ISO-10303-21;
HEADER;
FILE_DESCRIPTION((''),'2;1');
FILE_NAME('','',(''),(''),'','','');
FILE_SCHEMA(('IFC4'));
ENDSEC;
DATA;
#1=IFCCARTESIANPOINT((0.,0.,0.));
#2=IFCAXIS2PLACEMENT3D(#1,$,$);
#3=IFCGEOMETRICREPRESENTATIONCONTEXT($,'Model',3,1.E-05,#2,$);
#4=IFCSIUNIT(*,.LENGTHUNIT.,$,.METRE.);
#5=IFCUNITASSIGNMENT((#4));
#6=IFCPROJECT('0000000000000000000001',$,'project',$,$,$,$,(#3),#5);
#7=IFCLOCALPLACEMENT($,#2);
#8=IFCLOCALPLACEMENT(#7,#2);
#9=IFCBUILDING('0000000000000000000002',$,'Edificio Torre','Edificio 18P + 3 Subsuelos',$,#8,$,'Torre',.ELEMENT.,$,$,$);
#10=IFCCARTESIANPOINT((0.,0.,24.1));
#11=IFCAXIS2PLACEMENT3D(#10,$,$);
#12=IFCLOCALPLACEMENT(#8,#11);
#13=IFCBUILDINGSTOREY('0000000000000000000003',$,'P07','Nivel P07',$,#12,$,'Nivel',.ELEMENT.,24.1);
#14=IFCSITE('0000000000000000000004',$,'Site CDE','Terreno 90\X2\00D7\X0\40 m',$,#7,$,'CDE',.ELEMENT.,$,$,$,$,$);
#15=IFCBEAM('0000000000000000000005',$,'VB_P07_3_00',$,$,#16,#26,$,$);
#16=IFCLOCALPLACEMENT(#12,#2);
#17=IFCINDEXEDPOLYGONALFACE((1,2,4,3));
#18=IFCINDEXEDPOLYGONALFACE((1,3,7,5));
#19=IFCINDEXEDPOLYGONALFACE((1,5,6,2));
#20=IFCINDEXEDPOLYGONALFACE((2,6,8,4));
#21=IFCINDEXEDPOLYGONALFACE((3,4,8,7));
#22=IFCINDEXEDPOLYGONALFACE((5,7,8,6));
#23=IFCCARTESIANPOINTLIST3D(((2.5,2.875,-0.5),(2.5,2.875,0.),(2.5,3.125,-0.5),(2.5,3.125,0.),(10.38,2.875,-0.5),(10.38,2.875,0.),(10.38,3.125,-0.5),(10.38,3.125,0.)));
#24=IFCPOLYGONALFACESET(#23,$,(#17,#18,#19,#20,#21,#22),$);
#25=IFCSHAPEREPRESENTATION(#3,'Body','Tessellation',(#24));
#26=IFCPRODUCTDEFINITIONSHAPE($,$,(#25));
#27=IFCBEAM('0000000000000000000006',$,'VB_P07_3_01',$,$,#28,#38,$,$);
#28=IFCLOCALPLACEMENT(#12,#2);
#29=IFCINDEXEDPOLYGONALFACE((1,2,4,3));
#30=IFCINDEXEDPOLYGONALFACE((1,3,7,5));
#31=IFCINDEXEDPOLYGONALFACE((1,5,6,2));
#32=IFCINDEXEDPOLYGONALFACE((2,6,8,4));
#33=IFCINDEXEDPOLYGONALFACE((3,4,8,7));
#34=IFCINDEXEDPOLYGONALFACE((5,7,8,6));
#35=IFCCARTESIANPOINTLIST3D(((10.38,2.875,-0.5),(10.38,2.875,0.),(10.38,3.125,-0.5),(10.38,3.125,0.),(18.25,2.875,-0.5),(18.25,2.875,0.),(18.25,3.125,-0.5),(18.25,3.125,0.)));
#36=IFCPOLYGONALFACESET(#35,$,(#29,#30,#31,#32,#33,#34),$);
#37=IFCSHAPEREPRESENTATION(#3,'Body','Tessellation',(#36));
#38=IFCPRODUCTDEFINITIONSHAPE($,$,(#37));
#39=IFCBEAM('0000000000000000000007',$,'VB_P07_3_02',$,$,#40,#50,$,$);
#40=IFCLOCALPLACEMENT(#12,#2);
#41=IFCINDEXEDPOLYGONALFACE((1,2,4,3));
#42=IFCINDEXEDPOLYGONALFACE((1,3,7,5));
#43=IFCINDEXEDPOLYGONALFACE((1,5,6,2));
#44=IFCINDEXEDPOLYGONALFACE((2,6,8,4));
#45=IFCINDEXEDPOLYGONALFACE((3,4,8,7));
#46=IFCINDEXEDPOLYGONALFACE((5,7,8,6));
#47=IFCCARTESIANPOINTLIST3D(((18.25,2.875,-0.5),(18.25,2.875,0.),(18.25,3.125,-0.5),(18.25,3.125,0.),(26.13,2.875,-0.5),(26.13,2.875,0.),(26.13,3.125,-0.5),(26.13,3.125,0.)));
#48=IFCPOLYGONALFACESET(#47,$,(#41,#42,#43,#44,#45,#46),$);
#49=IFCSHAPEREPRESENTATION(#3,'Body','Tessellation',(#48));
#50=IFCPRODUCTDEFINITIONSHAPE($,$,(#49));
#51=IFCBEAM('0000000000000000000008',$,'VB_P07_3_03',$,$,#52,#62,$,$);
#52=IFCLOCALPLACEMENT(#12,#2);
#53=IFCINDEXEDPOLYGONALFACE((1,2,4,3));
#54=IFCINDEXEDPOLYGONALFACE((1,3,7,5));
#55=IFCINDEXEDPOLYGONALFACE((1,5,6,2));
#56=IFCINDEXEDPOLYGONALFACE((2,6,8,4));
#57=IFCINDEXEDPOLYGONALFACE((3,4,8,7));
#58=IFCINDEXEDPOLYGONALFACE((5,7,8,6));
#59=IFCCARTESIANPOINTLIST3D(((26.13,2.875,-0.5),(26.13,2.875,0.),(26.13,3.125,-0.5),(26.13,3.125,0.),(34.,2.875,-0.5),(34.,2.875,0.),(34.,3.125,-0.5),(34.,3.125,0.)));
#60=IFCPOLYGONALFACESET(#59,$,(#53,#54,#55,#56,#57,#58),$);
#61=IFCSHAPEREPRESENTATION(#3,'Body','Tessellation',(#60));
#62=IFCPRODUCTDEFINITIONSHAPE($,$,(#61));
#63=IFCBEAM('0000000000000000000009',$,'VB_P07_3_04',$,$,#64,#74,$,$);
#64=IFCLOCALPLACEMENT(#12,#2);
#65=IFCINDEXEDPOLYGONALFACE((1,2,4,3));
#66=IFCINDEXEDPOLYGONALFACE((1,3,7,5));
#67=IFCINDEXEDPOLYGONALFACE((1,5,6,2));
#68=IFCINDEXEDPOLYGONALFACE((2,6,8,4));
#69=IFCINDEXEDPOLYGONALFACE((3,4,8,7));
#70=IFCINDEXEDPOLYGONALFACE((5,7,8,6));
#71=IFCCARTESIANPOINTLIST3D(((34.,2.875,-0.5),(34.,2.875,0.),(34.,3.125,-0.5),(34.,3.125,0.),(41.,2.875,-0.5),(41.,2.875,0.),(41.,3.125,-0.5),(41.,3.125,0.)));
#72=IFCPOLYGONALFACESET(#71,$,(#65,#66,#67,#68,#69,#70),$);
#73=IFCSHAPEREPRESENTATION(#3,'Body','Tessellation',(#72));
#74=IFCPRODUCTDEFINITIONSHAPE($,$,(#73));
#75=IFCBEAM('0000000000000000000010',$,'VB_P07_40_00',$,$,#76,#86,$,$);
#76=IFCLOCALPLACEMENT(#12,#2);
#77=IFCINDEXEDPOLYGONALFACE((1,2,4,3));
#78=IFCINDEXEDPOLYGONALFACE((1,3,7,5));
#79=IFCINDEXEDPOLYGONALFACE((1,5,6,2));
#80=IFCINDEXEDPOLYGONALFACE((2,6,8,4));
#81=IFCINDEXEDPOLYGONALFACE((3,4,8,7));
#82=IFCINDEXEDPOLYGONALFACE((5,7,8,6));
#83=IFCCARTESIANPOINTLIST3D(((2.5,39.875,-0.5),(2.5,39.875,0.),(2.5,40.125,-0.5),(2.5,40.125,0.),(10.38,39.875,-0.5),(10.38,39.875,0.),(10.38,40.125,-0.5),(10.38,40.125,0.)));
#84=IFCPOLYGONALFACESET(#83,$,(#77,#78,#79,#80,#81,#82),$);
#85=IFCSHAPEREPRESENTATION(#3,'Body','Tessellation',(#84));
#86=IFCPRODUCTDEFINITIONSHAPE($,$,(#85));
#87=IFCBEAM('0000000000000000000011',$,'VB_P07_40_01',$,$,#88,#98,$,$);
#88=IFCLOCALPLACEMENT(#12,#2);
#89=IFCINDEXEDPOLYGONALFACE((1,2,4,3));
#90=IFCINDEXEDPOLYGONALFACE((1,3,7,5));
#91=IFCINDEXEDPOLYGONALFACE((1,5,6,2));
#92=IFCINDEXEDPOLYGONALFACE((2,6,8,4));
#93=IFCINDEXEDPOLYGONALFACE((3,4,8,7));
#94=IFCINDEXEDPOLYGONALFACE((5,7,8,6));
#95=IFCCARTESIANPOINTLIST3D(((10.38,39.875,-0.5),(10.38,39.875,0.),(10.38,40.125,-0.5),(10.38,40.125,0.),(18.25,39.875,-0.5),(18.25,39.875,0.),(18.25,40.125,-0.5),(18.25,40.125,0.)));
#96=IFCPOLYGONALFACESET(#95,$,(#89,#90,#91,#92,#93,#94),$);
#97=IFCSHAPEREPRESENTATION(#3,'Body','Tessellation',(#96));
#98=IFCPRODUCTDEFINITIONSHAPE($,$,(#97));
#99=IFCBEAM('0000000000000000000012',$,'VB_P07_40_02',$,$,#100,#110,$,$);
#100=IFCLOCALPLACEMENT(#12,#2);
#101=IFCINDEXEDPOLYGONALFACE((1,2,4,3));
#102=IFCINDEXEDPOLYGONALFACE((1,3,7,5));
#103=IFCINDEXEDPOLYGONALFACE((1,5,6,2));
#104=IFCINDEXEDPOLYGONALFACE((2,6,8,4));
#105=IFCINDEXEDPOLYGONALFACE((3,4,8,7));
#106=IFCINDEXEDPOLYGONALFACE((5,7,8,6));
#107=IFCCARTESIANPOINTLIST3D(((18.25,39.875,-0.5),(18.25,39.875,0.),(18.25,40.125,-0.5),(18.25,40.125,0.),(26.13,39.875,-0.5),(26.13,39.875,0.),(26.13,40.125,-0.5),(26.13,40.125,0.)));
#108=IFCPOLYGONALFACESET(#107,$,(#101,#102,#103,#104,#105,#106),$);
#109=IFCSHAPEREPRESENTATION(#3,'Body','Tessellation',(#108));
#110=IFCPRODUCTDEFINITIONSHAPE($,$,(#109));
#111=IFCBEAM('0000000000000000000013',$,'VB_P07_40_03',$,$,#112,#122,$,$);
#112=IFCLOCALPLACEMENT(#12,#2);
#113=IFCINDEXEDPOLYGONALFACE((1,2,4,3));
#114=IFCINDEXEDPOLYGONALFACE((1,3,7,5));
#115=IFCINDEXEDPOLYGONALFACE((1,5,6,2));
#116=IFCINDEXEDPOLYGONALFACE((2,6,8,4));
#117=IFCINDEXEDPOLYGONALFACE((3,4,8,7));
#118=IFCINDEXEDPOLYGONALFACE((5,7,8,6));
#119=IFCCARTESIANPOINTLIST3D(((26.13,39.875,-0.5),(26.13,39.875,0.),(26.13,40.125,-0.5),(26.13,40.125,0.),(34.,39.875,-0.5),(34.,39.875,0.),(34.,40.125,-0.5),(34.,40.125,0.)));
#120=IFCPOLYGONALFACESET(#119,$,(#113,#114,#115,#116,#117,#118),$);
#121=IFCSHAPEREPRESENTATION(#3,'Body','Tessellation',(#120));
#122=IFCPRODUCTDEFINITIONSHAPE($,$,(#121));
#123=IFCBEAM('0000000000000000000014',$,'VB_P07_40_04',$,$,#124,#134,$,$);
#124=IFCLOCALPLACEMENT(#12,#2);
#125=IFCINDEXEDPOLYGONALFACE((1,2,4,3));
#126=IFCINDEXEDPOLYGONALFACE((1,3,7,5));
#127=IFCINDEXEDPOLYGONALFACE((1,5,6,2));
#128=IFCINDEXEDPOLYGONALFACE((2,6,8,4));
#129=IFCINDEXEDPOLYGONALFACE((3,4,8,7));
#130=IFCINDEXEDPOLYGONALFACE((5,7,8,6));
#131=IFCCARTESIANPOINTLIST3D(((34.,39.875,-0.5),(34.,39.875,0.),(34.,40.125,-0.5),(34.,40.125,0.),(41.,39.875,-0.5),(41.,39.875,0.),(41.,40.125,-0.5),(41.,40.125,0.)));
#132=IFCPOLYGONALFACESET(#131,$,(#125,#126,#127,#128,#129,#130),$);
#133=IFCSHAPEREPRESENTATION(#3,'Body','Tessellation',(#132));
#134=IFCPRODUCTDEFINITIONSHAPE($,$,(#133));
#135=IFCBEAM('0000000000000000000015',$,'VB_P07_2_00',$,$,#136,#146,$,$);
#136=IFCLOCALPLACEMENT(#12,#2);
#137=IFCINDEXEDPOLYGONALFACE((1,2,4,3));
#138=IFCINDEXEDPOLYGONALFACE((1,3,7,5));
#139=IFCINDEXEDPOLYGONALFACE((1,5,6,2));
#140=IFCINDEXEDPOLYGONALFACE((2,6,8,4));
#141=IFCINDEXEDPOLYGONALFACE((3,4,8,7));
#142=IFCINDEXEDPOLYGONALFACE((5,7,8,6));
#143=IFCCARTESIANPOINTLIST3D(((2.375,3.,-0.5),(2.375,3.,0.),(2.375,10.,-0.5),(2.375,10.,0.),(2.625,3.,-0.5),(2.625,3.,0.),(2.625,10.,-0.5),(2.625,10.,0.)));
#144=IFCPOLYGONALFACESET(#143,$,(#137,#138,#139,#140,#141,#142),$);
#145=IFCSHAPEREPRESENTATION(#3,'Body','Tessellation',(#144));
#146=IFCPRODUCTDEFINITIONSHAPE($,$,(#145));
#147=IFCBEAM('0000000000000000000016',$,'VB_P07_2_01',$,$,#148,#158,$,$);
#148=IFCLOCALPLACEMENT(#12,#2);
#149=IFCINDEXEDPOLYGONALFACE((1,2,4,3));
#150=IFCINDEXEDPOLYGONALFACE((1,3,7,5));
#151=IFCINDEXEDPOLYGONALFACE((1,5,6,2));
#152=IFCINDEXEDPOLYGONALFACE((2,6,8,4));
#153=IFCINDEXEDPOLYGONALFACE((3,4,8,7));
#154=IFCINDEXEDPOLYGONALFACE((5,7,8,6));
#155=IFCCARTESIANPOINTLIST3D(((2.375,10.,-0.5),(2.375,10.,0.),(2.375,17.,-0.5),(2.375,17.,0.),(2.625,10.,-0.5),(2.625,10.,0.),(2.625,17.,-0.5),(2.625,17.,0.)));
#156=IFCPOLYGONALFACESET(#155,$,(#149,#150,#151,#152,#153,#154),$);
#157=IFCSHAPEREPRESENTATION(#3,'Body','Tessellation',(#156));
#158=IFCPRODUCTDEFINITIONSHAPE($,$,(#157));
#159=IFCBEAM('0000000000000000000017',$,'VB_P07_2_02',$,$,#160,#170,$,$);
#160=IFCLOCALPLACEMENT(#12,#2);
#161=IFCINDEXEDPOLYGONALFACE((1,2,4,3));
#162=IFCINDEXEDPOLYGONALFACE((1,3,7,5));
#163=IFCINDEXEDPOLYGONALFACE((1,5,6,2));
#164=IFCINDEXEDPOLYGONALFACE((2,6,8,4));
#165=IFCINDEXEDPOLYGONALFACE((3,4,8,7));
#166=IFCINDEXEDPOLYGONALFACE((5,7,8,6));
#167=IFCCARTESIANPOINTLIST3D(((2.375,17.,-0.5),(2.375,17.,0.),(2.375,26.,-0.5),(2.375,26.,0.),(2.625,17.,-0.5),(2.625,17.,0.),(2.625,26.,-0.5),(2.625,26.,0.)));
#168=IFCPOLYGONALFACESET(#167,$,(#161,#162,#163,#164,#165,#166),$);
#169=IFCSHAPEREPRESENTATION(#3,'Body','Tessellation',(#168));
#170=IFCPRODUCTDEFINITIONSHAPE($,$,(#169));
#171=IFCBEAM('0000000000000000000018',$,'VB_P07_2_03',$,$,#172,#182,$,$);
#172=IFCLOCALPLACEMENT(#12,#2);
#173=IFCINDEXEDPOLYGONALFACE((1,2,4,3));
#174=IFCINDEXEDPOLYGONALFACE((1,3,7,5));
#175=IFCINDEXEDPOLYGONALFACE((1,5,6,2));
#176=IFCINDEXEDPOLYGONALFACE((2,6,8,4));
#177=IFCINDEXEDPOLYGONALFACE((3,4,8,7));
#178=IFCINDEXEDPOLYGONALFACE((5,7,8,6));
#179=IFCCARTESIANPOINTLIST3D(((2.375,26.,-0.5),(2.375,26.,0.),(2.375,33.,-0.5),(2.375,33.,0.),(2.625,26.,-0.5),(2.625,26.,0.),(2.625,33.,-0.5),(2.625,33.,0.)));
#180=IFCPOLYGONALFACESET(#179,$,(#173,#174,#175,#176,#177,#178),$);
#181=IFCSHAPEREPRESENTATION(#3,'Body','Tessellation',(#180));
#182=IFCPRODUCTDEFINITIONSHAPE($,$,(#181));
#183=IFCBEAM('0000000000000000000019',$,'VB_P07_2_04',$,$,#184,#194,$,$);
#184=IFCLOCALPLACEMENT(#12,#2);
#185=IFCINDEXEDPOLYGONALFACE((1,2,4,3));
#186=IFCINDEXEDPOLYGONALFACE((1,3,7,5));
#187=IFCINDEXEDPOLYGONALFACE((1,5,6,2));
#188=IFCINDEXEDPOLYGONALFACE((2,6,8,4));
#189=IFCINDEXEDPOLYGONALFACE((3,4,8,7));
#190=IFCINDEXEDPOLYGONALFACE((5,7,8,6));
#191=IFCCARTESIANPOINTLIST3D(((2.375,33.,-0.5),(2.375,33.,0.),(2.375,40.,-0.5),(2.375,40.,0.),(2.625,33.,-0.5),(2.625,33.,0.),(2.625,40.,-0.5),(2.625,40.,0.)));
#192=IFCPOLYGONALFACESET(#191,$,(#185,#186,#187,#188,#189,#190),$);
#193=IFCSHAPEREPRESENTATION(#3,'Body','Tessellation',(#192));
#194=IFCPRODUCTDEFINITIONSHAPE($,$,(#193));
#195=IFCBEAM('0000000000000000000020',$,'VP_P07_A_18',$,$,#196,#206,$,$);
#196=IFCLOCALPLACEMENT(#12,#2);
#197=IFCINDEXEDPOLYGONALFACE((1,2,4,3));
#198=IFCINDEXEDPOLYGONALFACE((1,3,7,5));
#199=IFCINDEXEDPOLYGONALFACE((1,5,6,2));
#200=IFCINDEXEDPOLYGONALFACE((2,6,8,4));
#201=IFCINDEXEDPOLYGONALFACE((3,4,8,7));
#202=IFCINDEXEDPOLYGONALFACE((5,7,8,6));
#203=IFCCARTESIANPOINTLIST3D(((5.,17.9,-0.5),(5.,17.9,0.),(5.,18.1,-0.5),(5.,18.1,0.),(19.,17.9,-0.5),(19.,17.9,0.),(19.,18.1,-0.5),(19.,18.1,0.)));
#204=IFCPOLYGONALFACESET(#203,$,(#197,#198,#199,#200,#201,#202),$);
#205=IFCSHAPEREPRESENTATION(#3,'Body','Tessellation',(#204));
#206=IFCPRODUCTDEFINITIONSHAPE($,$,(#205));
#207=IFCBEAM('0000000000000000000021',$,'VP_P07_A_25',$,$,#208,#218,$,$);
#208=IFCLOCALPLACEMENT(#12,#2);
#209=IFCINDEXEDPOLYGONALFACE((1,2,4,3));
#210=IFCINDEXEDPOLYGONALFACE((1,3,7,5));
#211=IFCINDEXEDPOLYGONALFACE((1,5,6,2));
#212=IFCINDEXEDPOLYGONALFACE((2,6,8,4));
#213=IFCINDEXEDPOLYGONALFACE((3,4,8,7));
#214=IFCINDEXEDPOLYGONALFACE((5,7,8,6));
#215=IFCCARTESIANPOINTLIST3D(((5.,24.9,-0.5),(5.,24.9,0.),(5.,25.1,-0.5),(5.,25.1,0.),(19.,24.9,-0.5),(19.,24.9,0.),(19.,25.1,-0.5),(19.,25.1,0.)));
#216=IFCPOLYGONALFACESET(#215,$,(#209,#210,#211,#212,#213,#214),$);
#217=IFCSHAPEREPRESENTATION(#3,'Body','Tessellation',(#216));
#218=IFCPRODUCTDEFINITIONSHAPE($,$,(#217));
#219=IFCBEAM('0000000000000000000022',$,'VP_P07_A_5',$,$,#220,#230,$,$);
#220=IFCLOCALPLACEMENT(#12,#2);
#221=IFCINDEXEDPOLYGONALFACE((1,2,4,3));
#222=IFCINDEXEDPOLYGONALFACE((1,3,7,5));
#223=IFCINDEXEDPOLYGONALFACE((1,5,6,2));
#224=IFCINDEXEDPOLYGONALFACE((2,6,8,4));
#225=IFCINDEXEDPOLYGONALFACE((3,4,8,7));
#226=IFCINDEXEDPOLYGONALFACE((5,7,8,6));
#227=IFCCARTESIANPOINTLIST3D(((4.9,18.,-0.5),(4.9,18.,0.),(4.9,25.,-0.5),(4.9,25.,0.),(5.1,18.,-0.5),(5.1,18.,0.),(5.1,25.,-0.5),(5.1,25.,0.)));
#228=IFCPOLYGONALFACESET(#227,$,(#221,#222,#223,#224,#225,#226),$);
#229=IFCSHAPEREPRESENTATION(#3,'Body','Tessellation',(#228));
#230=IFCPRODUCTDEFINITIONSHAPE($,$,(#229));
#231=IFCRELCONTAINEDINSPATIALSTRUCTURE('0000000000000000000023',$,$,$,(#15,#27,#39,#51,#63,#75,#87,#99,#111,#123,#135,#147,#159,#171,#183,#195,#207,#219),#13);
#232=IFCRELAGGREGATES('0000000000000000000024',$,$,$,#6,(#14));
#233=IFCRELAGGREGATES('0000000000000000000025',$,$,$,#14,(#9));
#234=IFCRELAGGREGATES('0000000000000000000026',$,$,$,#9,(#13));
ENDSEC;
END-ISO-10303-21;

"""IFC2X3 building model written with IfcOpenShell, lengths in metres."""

from ifc_helpers import new_model, si_unit, frame, origin, origin_2d, place, context, project, spatial, rectangle, extrude, element, save


model = new_model("IFC2X3")

# Units and contexts
model_context = context("Model", 3, precision=1e-05, world=origin())
ifc_project = project(units=[si_unit("LENGTHUNIT", "METRE")], contexts=[model_context])

# Site, building, storey
site_placement = place(None, origin())
site = spatial("IfcSite", under=ifc_project, at=site_placement, Name="Site CDE", Description="Terreno 90×40 m", LongName="CDE", CompositionType="ELEMENT")
building_placement = place(site_placement, origin())
building = spatial("IfcBuilding", under=site, at=building_placement, Name="Edificio Torre", Description="Edificio 18P + 3 Subsuelos", LongName="Torre", CompositionType="ELEMENT")
storey_placement = place(building_placement, frame((0.0, 0.0, 24.1)))
storey = spatial("IfcBuildingStorey", under=building, at=storey_placement, Name="P07", Description="Nivel P07", LongName="Nivel", CompositionType="ELEMENT", Elevation=24.1)

# Beams
beam_1_placement = place(storey_placement, frame((6.44, 3.0, -0.5)))
element("IfcBeam", 1, at=beam_1_placement, inside=storey, Name="VB_P07_3_00", context=model_context, shape_type="SweptSolid", body=[
    extrude(rectangle(XDim=7.88, YDim=0.25, at=origin_2d()), origin(), (0.0, 0.0, 1.0), 0.5),
])
beam_2_placement = place(storey_placement, frame((14.315, 3.0, -0.5)))
element("IfcBeam", 2, at=beam_2_placement, inside=storey, Name="VB_P07_3_01", context=model_context, shape_type="SweptSolid", body=[
    extrude(rectangle(XDim=7.87, YDim=0.25, at=origin_2d()), origin(), (0.0, 0.0, 1.0), 0.5),
])
beam_3_placement = place(storey_placement, frame((22.19, 3.0, -0.5)))
element("IfcBeam", 3, at=beam_3_placement, inside=storey, Name="VB_P07_3_02", context=model_context, shape_type="SweptSolid", body=[
    extrude(rectangle(XDim=7.88, YDim=0.25, at=origin_2d()), origin(), (0.0, 0.0, 1.0), 0.5),
])
beam_4_placement = place(storey_placement, frame((30.065, 3.0, -0.5)))
element("IfcBeam", 4, at=beam_4_placement, inside=storey, Name="VB_P07_3_03", context=model_context, shape_type="SweptSolid", body=[
    extrude(rectangle(XDim=7.87, YDim=0.25, at=origin_2d()), origin(), (0.0, 0.0, 1.0), 0.5),
])
beam_5_placement = place(storey_placement, frame((37.5, 3.0, -0.5)))
element("IfcBeam", 5, at=beam_5_placement, inside=storey, Name="VB_P07_3_04", context=model_context, shape_type="SweptSolid", body=[
    extrude(rectangle(XDim=7.0, YDim=0.25, at=origin_2d()), origin(), (0.0, 0.0, 1.0), 0.5),
])
beam_6_placement = place(storey_placement, frame((6.44, 40.0, -0.5)))
element("IfcBeam", 6, at=beam_6_placement, inside=storey, Name="VB_P07_40_00", context=model_context, shape_type="SweptSolid", body=[
    extrude(rectangle(XDim=7.88, YDim=0.25, at=origin_2d()), origin(), (0.0, 0.0, 1.0), 0.5),
])
beam_7_placement = place(storey_placement, frame((14.315, 40.0, -0.5)))
element("IfcBeam", 7, at=beam_7_placement, inside=storey, Name="VB_P07_40_01", context=model_context, shape_type="SweptSolid", body=[
    extrude(rectangle(XDim=7.87, YDim=0.25, at=origin_2d()), origin(), (0.0, 0.0, 1.0), 0.5),
])
beam_8_placement = place(storey_placement, frame((22.19, 40.0, -0.5)))
element("IfcBeam", 8, at=beam_8_placement, inside=storey, Name="VB_P07_40_02", context=model_context, shape_type="SweptSolid", body=[
    extrude(rectangle(XDim=7.88, YDim=0.25, at=origin_2d()), origin(), (0.0, 0.0, 1.0), 0.5),
])
beam_9_placement = place(storey_placement, frame((30.065, 40.0, -0.5)))
element("IfcBeam", 9, at=beam_9_placement, inside=storey, Name="VB_P07_40_03", context=model_context, shape_type="SweptSolid", body=[
    extrude(rectangle(XDim=7.87, YDim=0.25, at=origin_2d()), origin(), (0.0, 0.0, 1.0), 0.5),
])
beam_10_placement = place(storey_placement, frame((37.5, 40.0, -0.5)))
element("IfcBeam", 10, at=beam_10_placement, inside=storey, Name="VB_P07_40_04", context=model_context, shape_type="SweptSolid", body=[
    extrude(rectangle(XDim=7.0, YDim=0.25, at=origin_2d()), origin(), (0.0, 0.0, 1.0), 0.5),
])
for number, where, name in (
    (11, (2.5, 6.5, -0.5), "VB_P07_2_00"),
    (12, (2.5, 13.5, -0.5), "VB_P07_2_01"),
):
    element("IfcBeam", number, at=place(storey_placement, frame(where)), inside=storey, Name=name, context=model_context, shape_type="SweptSolid", body=[
        extrude(rectangle(XDim=0.25, YDim=7.0, at=origin_2d()), origin(), (0.0, 0.0, 1.0), 0.5),
    ])
beam_11_placement = place(storey_placement, frame((2.5, 21.5, -0.5)))
element("IfcBeam", 13, at=beam_11_placement, inside=storey, Name="VB_P07_2_02", context=model_context, shape_type="SweptSolid", body=[
    extrude(rectangle(XDim=0.25, YDim=9.0, at=origin_2d()), origin(), (0.0, 0.0, 1.0), 0.5),
])
for number, where, name in (
    (14, (2.5, 29.5, -0.5), "VB_P07_2_03"),
    (15, (2.5, 36.5, -0.5), "VB_P07_2_04"),
):
    element("IfcBeam", number, at=place(storey_placement, frame(where)), inside=storey, Name=name, context=model_context, shape_type="SweptSolid", body=[
        extrude(rectangle(XDim=0.25, YDim=7.0, at=origin_2d()), origin(), (0.0, 0.0, 1.0), 0.5),
    ])
for number, where, name in (
    (16, (12.0, 18.0, -0.5), "VP_P07_A_18"),
    (17, (12.0, 25.0, -0.5), "VP_P07_A_25"),
):
    element("IfcBeam", number, at=place(storey_placement, frame(where)), inside=storey, Name=name, context=model_context, shape_type="SweptSolid", body=[
        extrude(rectangle(XDim=14.0, YDim=0.2, at=origin_2d()), origin(), (0.0, 0.0, 1.0), 0.5),
    ])
beam_12_placement = place(storey_placement, frame((5.0, 21.5, -0.5)))
element("IfcBeam", 18, at=beam_12_placement, inside=storey, Name="VP_P07_A_5", context=model_context, shape_type="SweptSolid", body=[
    extrude(rectangle(XDim=0.2, YDim=7.0, at=origin_2d()), origin(), (0.0, 0.0, 1.0), 0.5),
])

save(model, "model.ifc")
